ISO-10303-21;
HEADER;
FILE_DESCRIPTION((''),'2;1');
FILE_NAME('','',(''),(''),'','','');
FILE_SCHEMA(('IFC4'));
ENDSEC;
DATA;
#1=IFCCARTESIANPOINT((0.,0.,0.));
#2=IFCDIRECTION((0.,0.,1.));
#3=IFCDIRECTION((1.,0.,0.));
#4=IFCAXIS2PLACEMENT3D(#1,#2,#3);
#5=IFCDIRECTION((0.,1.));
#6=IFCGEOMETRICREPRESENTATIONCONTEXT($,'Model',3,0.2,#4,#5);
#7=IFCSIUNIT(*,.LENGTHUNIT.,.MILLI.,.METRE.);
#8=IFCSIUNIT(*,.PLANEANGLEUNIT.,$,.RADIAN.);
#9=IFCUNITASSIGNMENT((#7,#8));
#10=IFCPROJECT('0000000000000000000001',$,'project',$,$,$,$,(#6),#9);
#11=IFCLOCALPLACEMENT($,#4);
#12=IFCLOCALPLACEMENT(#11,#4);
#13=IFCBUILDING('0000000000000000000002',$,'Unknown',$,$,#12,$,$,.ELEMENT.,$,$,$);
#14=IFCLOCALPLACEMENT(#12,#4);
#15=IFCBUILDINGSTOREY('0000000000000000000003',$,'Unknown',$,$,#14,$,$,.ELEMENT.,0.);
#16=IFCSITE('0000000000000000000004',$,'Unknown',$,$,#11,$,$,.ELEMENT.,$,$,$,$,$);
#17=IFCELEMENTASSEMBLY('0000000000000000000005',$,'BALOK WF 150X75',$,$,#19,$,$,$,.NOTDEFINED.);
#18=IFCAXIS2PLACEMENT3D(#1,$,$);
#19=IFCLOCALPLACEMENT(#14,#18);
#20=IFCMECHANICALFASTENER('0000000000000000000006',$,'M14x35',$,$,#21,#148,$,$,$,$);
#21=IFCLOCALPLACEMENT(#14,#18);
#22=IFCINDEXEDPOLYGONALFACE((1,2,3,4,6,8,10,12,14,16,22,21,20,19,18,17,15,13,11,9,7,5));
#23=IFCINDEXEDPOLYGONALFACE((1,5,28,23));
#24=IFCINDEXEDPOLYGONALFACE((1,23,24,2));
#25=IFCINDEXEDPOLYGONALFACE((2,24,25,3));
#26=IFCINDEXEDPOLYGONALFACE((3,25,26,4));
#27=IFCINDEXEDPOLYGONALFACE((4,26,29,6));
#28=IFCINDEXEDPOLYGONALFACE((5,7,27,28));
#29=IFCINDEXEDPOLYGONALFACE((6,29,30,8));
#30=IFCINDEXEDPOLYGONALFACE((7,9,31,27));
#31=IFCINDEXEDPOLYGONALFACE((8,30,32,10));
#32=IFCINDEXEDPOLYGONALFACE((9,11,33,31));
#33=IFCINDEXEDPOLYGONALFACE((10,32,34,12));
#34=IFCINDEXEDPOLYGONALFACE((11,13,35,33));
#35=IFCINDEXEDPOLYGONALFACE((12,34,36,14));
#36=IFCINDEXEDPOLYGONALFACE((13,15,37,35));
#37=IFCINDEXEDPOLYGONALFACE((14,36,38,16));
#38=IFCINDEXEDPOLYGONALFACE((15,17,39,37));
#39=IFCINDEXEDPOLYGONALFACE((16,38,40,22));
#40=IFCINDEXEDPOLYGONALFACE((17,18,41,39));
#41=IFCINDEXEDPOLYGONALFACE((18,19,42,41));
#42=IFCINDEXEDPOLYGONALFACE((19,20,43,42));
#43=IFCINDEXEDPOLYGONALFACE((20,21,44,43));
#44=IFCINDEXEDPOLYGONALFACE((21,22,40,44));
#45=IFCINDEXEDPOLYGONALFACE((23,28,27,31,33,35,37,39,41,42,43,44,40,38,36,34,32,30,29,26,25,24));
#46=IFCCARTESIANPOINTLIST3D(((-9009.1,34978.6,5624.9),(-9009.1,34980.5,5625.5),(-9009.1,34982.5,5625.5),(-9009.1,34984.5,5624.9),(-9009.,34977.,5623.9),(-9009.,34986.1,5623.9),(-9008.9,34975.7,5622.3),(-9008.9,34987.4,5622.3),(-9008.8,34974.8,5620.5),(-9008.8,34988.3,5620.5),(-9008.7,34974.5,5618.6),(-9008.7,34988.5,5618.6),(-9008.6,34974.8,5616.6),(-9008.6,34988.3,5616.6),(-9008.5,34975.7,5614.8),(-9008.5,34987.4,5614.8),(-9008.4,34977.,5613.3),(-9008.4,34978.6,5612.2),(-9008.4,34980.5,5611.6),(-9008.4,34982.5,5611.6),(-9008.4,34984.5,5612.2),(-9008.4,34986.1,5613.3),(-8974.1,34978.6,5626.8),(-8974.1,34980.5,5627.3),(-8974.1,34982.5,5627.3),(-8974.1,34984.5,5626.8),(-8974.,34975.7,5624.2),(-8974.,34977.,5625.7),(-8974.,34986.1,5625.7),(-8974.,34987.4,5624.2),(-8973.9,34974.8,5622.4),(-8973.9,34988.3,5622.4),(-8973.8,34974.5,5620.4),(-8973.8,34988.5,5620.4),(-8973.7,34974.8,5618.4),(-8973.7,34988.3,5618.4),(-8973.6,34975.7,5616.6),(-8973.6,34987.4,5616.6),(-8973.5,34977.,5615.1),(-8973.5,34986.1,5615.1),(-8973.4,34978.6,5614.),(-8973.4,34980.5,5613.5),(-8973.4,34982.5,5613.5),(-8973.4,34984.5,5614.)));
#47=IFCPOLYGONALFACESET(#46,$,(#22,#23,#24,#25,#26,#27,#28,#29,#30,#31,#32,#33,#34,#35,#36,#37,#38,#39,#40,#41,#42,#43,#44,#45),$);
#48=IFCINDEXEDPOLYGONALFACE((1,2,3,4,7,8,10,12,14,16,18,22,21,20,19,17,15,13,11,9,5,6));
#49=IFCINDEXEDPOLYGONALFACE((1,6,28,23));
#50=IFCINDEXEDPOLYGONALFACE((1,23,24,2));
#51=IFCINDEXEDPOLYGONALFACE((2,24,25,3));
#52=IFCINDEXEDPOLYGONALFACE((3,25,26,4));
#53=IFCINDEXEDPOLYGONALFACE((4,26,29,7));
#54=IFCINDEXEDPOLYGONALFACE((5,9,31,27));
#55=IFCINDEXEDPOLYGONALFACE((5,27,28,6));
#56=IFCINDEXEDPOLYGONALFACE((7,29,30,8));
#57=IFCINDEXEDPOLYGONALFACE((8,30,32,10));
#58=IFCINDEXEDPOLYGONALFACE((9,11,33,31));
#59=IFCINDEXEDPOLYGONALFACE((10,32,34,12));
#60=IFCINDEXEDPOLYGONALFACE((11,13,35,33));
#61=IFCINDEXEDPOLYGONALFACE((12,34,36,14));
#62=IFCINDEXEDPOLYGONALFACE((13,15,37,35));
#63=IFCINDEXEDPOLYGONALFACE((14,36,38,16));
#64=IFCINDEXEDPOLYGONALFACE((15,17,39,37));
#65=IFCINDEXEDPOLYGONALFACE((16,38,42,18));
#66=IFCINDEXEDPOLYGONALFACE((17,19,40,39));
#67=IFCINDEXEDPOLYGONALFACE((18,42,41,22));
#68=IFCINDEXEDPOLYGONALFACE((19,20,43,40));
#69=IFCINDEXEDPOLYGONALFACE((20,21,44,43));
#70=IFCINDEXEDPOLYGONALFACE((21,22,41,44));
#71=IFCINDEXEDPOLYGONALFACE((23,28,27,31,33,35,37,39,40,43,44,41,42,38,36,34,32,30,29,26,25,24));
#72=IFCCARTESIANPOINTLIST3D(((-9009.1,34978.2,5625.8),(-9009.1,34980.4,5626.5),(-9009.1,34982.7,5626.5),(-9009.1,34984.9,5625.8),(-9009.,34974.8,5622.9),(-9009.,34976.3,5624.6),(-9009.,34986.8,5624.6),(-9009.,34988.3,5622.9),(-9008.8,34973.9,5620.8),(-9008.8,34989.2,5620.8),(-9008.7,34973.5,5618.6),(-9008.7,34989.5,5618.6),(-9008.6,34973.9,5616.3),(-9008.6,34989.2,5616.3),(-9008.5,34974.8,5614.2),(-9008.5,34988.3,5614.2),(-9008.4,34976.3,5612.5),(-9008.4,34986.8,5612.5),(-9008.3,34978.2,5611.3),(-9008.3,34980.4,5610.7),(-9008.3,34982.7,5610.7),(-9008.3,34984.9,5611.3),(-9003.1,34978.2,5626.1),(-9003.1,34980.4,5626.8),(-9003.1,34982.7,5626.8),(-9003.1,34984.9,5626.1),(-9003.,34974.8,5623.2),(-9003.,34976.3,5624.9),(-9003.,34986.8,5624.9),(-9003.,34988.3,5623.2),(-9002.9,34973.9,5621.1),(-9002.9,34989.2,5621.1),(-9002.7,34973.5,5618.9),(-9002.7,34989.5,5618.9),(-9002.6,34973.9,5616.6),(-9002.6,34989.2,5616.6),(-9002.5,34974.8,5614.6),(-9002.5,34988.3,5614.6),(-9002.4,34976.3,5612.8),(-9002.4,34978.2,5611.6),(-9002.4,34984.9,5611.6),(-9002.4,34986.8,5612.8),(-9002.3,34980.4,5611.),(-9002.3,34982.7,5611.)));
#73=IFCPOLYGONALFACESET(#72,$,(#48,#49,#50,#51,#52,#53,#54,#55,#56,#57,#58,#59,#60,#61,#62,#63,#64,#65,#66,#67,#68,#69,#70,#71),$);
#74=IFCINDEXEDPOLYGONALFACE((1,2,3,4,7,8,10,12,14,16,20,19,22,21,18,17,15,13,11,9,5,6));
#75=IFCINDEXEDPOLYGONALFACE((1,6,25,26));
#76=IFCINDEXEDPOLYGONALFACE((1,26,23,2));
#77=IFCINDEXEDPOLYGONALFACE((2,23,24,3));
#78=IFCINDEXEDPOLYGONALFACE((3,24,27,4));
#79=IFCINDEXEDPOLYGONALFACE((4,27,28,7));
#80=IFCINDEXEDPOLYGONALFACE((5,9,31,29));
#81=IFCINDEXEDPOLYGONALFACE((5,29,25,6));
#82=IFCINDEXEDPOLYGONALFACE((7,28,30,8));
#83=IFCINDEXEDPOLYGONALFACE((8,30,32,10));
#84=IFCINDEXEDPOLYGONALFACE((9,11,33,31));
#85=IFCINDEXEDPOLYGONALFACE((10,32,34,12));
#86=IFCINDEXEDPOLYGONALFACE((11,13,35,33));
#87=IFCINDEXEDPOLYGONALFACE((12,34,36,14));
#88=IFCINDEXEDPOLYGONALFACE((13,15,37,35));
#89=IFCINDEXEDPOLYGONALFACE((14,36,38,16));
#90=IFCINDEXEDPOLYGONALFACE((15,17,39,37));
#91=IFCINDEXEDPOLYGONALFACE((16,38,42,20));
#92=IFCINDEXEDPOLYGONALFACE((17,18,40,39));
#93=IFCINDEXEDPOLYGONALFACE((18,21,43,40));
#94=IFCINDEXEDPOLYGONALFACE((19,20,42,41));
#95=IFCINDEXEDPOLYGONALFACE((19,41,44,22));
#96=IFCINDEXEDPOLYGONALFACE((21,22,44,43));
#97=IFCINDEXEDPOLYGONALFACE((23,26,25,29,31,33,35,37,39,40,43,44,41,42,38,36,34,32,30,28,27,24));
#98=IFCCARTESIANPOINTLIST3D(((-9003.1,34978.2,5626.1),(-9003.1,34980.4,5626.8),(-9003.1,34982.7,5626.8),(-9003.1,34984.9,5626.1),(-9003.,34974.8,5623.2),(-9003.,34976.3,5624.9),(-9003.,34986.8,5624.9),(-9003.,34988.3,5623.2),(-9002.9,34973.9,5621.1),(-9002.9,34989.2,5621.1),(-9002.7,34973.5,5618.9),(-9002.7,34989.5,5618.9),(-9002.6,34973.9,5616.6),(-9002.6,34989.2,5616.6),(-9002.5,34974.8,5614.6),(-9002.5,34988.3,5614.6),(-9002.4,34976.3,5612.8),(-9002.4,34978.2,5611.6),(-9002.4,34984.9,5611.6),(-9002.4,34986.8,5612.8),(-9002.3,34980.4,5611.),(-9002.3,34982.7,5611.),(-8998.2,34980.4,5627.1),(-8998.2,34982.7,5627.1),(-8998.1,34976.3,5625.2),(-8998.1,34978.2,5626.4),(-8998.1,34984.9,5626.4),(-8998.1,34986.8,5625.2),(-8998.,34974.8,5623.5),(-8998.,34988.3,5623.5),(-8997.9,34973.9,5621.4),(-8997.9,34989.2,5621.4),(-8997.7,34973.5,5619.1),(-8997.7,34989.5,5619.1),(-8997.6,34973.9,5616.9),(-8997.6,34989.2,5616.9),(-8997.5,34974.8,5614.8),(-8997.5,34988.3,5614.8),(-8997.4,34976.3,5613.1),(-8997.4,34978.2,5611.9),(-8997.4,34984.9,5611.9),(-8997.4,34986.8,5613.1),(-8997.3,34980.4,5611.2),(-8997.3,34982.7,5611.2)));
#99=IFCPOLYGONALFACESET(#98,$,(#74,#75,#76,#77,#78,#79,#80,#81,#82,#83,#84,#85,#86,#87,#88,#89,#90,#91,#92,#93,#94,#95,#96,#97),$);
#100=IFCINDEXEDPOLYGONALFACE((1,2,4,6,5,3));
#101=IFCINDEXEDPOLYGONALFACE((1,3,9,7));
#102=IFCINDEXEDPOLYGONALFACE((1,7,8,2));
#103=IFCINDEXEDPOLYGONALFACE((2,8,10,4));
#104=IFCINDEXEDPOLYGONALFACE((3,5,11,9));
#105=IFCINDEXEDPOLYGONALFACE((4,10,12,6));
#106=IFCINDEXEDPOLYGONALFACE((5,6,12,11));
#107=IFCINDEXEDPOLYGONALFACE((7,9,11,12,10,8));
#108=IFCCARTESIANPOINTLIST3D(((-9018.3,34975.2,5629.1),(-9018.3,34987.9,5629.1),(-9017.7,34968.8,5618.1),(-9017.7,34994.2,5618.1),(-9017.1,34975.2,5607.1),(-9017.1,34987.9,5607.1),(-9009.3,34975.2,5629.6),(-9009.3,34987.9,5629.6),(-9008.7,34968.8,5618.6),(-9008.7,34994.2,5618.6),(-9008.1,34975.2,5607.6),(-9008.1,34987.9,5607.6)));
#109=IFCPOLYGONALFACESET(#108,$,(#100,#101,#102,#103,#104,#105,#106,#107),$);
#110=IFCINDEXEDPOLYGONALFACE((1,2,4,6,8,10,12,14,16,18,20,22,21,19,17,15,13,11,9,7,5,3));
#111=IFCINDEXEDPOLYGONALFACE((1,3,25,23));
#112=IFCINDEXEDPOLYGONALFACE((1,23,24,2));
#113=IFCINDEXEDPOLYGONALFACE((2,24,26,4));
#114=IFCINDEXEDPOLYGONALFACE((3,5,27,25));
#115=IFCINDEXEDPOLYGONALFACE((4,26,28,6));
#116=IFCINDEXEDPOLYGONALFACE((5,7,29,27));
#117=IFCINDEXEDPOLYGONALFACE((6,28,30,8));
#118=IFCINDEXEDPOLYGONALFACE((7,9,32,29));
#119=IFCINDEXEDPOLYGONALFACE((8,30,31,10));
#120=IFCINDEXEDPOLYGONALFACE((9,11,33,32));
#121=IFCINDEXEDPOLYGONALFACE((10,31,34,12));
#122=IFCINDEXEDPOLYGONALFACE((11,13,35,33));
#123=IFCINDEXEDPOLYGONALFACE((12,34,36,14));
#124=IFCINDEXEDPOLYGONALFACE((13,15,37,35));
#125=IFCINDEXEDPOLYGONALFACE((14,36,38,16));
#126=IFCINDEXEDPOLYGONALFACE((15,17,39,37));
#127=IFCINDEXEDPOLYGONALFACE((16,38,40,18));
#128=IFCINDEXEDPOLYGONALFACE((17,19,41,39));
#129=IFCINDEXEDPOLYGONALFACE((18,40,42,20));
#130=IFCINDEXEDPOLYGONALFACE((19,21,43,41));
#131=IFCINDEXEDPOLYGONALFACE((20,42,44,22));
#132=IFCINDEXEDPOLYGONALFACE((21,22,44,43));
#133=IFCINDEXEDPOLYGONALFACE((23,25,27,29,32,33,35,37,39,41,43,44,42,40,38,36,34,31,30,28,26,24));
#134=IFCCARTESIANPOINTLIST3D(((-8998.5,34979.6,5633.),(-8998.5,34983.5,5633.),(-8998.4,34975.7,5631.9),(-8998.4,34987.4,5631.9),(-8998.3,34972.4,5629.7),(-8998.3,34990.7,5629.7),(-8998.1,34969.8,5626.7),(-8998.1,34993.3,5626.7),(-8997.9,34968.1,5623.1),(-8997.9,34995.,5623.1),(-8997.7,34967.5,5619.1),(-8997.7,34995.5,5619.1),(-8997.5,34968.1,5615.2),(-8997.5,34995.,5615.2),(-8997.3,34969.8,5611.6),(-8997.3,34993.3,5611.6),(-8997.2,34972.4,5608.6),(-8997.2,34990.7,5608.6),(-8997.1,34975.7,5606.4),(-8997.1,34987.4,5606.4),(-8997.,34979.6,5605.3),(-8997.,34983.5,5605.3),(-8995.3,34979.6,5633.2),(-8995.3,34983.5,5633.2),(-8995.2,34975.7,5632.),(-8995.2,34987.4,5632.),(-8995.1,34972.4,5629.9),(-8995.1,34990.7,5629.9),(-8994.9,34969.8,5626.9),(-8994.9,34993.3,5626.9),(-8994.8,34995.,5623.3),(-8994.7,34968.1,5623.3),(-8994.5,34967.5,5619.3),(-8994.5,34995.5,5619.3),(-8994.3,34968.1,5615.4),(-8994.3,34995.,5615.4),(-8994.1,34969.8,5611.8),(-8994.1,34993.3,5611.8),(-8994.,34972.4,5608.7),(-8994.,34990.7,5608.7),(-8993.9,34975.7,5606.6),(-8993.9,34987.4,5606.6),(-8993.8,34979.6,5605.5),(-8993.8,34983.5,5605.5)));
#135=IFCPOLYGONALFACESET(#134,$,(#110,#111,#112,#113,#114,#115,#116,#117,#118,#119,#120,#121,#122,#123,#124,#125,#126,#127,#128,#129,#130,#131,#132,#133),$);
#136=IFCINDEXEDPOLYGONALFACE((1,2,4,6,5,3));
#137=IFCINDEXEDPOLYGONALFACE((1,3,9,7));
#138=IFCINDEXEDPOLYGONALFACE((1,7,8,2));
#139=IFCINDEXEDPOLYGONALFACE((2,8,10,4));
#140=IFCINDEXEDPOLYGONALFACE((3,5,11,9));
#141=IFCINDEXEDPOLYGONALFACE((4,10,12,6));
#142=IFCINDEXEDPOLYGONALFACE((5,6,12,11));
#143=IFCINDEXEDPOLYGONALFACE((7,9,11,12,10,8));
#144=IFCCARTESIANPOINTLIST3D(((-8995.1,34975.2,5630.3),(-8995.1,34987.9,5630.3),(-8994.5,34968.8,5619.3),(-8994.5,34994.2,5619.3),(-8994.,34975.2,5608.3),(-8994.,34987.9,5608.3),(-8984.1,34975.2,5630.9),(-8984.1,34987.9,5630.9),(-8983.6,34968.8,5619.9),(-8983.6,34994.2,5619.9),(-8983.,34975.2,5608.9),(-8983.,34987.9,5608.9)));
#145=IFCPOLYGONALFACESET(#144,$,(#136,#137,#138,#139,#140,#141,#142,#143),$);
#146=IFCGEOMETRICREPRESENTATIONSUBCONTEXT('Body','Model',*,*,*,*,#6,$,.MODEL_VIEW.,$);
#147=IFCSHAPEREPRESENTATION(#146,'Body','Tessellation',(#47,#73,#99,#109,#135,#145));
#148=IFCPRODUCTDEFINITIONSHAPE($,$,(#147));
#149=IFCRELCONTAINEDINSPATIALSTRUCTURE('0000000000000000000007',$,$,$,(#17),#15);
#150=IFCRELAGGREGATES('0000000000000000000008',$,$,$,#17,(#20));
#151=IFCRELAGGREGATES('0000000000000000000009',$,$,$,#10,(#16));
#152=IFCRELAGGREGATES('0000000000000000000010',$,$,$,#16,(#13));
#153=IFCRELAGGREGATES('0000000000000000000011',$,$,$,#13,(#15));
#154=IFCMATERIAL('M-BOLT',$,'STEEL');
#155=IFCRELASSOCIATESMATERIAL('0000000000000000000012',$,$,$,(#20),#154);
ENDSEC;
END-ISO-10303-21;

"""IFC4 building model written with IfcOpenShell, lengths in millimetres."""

from ifc_helpers import new_model, si_unit, direction, frame, origin_with_axes, place, context, subcontext, project, spatial, line, arc, indexed_curve, outline, extrude, source, transform, mapped, material, element, aggregate, save


model = new_model("IFC4")

# Units and contexts
model_context = context("Model", 3, precision=0.2, world=origin_with_axes(), true_north=direction((0.0, 1.0)))
body_context = subcontext(model_context, "Body", "Model", "MODEL_VIEW")
ifc_project = project(units=[si_unit("LENGTHUNIT", "METRE", prefix="MILLI"), si_unit("PLANEANGLEUNIT", "RADIAN")], contexts=[model_context])

# Site, building, storey
site_placement = place(None, origin_with_axes())
site = spatial("IfcSite", under=ifc_project, at=site_placement, Name="Unknown", CompositionType="ELEMENT")
building_placement = place(site_placement, origin_with_axes())
building = spatial("IfcBuilding", under=site, at=building_placement, Name="Unknown", CompositionType="ELEMENT")
storey_placement = place(building_placement, origin_with_axes())
storey = spatial("IfcBuildingStorey", under=building, at=storey_placement, Name="Unknown", CompositionType="ELEMENT", Elevation=0.0)

# Shared definitions
ifc_material_1 = material(Name="M-BOLT", Category="STEEL")

# Element assembly
assembly_1_placement = place(storey_placement, frame((-9001.5, 35225.4, 5643.9), z_axis=(-0.99863, 0.0, -0.052336), x_axis=(0.0, -1.0, 0.000001)))
assembly_1 = element("IfcElementAssembly", 1, at=assembly_1_placement, inside=storey, Name="BALOK WF 150X75", PredefinedType="NOTDEFINED")

# Mechanical fastener
shared_shape_1 = source(origin_with_axes(), body_context, "Body", "SweptSolid", [
    extrude(outline(indexed_curve([(7.0, 0.0), (0.0, 7.0), (-7.0, 0.0), (0.0, -7.0)], segments=[arc(1, 2, 3), arc(3, 4, 1)])), frame((0.0, 0.0, -2.6), z_axis=(0.0, 0.0, -1.0), x_axis=(0.0, 1.0, 0.0)), (0.0, 0.0, 1.0), 35.0),
    extrude(outline(indexed_curve([(8.0, 0.0), (0.0, 8.0), (-8.0, 0.0), (0.0, -8.0)], segments=[arc(1, 2, 3), arc(3, 4, 1)])), frame((0.0, 0.0, -2.6), z_axis=(0.0, 0.0, -1.0), x_axis=(0.0, 1.0, 0.0)), (0.0, 0.0, 1.0), 6.0),
    extrude(outline(indexed_curve([(8.0, 0.0), (0.0, 8.0), (-8.0, 0.0), (0.0, -8.0)], segments=[arc(1, 2, 3), arc(3, 4, 1)])), frame((0.0, 0.0, -8.6), z_axis=(0.0, 0.0, -1.0), x_axis=(0.0, 1.0, 0.0)), (0.0, 0.0, 1.0), 5.0),
    extrude(outline(indexed_curve([(12.7, 0.0), (6.4, 11.0), (-6.4, 11.0), (-12.7, 0.0), (-6.4, -11.0), (6.4, -11.0)], segments=[line(1, 2, 3, 4, 5, 6, 1)])), frame((0.0, 0.0, 6.4), z_axis=(0.0, 0.0, -1.0), x_axis=(0.0, 1.0, 0.0)), (0.0, 0.0, 1.0), 9.0),
    extrude(outline(indexed_curve([(14.0, 0.0), (0.0, 14.0), (-14.0, 0.0), (0.0, -14.0)], segments=[arc(1, 2, 3), arc(3, 4, 1)])), frame((0.0, 0.0, -13.6), z_axis=(0.0, 0.0, -1.0), x_axis=(0.0, 1.0, 0.0)), (0.0, 0.0, 1.0), 3.2),
    extrude(outline(indexed_curve([(12.7, 0.0), (6.4, 11.0), (-6.4, 11.0), (-12.7, 0.0), (-6.4, -11.0), (6.4, -11.0)], segments=[line(1, 2, 3, 4, 5, 6, 1)])), frame((0.0, 0.0, -16.8), z_axis=(0.0, 0.0, -1.0), x_axis=(0.0, 1.0, 0.0)), (0.0, 0.0, 1.0), 11.0),
])
mechanical_fastener_1_placement = place(assembly_1_placement, frame((243.9, -24.9, 11.1), z_axis=(0.000006, 0.0, 1.0), x_axis=(-0.000001, -1.0, 0.0)))
mechanical_fastener_1 = element("IfcMechanicalFastener", 2, at=mechanical_fastener_1_placement, material=ifc_material_1, Name="M14x35", context=body_context, shape_type="MappedRepresentation", body=[
    mapped(shared_shape_1, transform((0.0, 0.0, 0.0))),
])
aggregate(assembly_1, [mechanical_fastener_1])

save(model, "model.ifc")
